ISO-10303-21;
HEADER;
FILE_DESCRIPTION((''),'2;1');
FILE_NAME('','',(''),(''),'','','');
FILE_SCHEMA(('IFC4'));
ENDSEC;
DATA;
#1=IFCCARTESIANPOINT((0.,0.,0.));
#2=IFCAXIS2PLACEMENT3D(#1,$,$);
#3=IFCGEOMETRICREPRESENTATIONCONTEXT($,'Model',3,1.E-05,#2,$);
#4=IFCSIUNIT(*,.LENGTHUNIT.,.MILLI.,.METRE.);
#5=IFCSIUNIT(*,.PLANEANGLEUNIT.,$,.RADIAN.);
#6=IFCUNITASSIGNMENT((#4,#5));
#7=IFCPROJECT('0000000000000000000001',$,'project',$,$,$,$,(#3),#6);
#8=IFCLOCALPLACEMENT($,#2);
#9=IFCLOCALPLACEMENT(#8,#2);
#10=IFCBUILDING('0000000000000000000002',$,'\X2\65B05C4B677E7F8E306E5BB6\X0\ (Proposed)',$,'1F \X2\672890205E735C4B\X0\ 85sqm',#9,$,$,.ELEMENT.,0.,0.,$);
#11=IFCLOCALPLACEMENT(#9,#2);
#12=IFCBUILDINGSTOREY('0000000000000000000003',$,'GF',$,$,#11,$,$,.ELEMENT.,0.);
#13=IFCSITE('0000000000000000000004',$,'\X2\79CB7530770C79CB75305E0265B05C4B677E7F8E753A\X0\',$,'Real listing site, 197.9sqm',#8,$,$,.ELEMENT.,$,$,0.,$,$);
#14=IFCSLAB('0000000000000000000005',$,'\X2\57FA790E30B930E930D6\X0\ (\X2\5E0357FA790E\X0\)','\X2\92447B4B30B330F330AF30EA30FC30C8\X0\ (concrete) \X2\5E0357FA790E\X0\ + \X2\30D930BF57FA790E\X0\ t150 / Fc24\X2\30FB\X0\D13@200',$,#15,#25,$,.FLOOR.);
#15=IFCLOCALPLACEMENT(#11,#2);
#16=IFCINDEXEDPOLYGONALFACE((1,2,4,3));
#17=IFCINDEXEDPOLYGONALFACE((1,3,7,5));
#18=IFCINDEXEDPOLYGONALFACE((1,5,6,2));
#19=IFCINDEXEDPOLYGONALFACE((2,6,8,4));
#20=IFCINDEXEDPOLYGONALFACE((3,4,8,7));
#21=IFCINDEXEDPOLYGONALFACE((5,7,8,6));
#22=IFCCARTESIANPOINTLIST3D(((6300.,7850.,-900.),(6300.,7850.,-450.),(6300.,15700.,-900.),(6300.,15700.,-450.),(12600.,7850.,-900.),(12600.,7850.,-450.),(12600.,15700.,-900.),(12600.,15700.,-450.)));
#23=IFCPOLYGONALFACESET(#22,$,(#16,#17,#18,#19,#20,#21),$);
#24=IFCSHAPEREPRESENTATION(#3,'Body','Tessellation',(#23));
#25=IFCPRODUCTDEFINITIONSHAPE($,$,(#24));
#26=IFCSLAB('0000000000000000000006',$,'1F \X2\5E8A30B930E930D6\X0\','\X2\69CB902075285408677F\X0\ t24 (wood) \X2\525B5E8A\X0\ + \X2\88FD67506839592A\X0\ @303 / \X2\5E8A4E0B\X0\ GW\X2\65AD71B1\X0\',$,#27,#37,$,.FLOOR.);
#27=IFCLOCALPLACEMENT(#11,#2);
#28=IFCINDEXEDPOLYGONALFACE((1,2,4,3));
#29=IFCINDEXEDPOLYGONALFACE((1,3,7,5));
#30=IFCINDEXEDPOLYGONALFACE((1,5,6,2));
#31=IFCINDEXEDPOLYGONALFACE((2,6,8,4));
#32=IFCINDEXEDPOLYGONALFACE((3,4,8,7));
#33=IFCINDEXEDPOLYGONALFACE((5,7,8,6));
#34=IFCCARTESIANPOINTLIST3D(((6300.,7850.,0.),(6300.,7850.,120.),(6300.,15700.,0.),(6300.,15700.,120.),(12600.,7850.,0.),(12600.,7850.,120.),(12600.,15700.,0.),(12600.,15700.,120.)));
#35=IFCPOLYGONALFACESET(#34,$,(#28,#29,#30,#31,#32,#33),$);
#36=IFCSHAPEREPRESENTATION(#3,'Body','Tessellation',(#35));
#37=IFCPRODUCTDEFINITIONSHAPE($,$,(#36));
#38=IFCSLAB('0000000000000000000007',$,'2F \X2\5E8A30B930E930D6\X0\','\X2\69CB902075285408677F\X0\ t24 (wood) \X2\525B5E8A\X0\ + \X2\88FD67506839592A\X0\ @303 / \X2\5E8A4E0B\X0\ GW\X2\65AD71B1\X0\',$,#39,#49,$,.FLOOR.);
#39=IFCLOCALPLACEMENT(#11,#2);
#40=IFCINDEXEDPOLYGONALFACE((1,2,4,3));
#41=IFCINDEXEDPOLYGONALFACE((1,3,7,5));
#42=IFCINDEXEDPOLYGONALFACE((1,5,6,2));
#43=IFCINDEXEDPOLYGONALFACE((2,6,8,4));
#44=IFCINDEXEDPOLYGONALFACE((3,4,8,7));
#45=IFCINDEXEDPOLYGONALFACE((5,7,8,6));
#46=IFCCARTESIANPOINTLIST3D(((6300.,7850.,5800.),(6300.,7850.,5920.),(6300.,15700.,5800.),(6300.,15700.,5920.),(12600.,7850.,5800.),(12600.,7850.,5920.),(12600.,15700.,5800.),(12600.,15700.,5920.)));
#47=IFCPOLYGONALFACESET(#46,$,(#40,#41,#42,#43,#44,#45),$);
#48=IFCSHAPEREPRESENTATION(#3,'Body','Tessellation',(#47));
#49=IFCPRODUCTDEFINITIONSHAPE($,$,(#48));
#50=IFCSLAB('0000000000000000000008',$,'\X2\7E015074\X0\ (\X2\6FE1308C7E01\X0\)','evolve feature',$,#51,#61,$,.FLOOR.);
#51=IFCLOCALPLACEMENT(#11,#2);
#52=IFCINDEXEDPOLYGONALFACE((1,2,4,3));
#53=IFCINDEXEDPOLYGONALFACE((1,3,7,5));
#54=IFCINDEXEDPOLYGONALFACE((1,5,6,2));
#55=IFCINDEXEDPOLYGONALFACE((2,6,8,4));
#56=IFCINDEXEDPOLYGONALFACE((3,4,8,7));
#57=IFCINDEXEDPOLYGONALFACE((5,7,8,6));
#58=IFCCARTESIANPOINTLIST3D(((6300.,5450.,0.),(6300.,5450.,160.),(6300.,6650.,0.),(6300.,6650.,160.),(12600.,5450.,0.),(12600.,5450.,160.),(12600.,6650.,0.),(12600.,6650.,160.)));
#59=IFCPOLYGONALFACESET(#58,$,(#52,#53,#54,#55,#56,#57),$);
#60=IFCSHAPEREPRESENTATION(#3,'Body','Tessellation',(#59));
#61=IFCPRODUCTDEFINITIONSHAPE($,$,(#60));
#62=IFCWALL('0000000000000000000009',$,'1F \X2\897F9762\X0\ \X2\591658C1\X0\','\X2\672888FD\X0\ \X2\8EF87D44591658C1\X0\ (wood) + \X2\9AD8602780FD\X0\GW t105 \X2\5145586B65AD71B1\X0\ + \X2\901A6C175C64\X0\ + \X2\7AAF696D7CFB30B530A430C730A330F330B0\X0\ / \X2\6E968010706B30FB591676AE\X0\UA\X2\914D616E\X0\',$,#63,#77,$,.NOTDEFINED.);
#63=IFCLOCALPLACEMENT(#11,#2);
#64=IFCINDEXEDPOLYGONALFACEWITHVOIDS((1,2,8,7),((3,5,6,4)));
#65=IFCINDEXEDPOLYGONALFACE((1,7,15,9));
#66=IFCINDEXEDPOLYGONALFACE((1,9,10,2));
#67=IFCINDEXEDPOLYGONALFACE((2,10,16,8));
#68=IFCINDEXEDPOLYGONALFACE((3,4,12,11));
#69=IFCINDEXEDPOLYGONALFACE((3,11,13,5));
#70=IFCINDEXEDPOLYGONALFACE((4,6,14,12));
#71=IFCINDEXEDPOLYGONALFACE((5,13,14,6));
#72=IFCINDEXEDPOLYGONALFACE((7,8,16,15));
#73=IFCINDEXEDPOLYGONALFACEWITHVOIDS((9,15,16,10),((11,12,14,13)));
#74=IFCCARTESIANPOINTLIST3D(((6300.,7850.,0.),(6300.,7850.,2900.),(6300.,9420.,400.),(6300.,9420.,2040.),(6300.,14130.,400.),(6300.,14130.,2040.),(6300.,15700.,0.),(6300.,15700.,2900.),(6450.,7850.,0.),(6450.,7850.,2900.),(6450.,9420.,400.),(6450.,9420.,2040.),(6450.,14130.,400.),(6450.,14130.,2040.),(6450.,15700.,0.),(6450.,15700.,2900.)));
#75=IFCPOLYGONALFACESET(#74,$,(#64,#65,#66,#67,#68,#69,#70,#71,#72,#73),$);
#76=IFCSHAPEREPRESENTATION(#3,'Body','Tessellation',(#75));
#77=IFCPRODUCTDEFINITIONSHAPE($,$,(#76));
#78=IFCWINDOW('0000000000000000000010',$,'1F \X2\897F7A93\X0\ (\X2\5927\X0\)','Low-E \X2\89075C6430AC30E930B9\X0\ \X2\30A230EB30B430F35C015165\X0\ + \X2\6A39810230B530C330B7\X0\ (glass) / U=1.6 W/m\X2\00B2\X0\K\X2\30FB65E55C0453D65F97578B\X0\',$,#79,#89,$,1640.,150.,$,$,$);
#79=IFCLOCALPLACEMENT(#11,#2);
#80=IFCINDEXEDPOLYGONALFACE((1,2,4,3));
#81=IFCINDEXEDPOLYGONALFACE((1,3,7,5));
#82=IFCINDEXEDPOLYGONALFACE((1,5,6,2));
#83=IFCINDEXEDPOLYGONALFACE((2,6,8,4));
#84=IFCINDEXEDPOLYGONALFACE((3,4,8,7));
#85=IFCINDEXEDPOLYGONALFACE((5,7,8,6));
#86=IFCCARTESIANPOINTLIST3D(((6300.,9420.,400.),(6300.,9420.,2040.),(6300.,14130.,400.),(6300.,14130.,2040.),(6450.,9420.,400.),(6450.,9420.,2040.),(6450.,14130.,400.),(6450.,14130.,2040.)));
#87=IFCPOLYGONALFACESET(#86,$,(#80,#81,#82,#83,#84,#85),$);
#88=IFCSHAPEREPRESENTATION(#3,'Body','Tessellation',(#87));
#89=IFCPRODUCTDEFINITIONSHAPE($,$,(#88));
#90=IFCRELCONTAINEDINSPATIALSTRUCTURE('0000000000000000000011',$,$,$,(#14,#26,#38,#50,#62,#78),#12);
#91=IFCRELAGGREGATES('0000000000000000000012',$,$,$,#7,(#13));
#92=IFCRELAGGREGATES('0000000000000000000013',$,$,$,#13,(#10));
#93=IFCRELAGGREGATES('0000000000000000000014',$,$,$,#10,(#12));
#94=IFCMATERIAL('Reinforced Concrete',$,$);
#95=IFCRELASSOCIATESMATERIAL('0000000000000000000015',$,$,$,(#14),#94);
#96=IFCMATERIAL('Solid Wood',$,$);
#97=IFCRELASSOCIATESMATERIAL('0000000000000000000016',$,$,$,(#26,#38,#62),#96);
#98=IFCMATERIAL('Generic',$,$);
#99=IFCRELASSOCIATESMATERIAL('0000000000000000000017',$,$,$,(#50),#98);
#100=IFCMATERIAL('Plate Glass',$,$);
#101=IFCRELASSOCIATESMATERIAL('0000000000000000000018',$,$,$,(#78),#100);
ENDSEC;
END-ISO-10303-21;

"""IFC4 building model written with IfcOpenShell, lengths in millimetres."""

from ifc_helpers import new_model, si_unit, frame, frame_2d, origin, place, context, project, spatial, rectangle, extrude, material, element, fill, save


model = new_model("IFC4")

# Units and contexts
model_context = context("Model", 3, precision=1e-05, world=origin())
ifc_project = project(units=[si_unit("LENGTHUNIT", "METRE", prefix="MILLI"), si_unit("PLANEANGLEUNIT", "RADIAN")], contexts=[model_context])

# Site, building, storey
site_placement = place(None, origin())
site = spatial("IfcSite", under=ifc_project, at=site_placement, Name="秋田県秋田市新屋松美町", ObjectType="Real listing site, 197.9sqm", CompositionType="ELEMENT", RefElevation=0.0)
building_placement = place(site_placement, origin())
building = spatial("IfcBuilding", under=site, at=building_placement, Name="新屋松美の家 (Proposed)", ObjectType="1F 木造平屋 85sqm", CompositionType="ELEMENT", ElevationOfRefHeight=0.0, ElevationOfTerrain=0.0)
storey_placement = place(building_placement, origin())
storey = spatial("IfcBuildingStorey", under=building, at=storey_placement, Name="GF", CompositionType="ELEMENT", Elevation=0.0)

# Slabs
ifc_material_1 = material(Name="Reinforced Concrete")
slab_1_placement = place(storey_placement, frame((3150.0, 3925.0, -450.0)))
element("IfcSlab", 1, at=slab_1_placement, inside=storey, material=ifc_material_1, Name="基礎スラブ (布基礎)", Description="鉄筋コンクリート (concrete) 布基礎 + ベタ基礎 t150 / Fc24・D13@200", PredefinedType="FLOOR", context=model_context, shape_type="SweptSolid", body=[
    extrude(rectangle(XDim=6300.0, YDim=7850.0, at=frame_2d((3150.0, 3925.0))), frame((3150.0, 3925.0, -450.0)), (0.0, 0.0, 1.0), 450.0),
])
ifc_material_2 = material(Name="Solid Wood")
slab_2_placement = place(storey_placement, frame((3150.0, 3925.0, 0.0)))
element("IfcSlab", 2, at=slab_2_placement, inside=storey, material=ifc_material_2, Name="1F 床スラブ", Description="構造用合板 t24 (wood) 剛床 + 製材根太 @303 / 床下 GW断熱", PredefinedType="FLOOR", context=model_context, shape_type="SweptSolid", body=[
    extrude(rectangle(XDim=6300.0, YDim=7850.0, at=frame_2d((3150.0, 3925.0))), frame((3150.0, 3925.0, 0.0)), (0.0, 0.0, 1.0), 120.0),
])
slab_3_placement = place(storey_placement, frame((3150.0, 3925.0, 2900.0)))
element("IfcSlab", 3, at=slab_3_placement, inside=storey, material=ifc_material_2, Name="2F 床スラブ", Description="構造用合板 t24 (wood) 剛床 + 製材根太 @303 / 床下 GW断熱", PredefinedType="FLOOR", context=model_context, shape_type="SweptSolid", body=[
    extrude(rectangle(XDim=6300.0, YDim=7850.0, at=frame_2d((3150.0, 3925.0))), frame((3150.0, 3925.0, 2900.0)), (0.0, 0.0, 1.0), 120.0),
])
ifc_material_3 = material(Name="Generic")
slab_4_placement = place(storey_placement, frame((3150.0, 2725.0, 0.0)))
element("IfcSlab", 4, at=slab_4_placement, inside=storey, material=ifc_material_3, Name="縁側 (濡れ縁)", Description="evolve feature", PredefinedType="FLOOR", context=model_context, shape_type="SweptSolid", body=[
    extrude(rectangle(XDim=6300.0, YDim=1200.0, at=frame_2d((3150.0, 600.0))), frame((3150.0, 2725.0, 0.0)), (0.0, 0.0, 1.0), 160.0),
])

# Shared definitions
ifc_material_4 = material(Name="Plate Glass")

# Wall, opening, window
wall_1_placement = place(storey_placement, frame((3150.0, 3925.0, 0.0)))
wall_1 = element("IfcWall", 5, at=wall_1_placement, inside=storey, material=ifc_material_2, Name="1F 西面 外壁", Description="木製 軸組外壁 (wood) + 高性能GW t105 充填断熱 + 通気層 + 窯業系サイディング / 準耐火・外皮UA配慮", PredefinedType="NOTDEFINED", context=model_context, shape_type="SweptSolid", body=[
    extrude(rectangle(XDim=150.0, YDim=7850.0, at=frame_2d((75.0, 3925.0))), frame((3150.0, 3925.0, 0.0)), (0.0, 0.0, 1.0), 2900.0),
])
opening_1_placement = place(storey_placement, frame((3150.0, 4710.0, 200.0)))
opening_1 = element("IfcOpeningElement", 6, at=opening_1_placement, cuts=wall_1, PredefinedType="NOTDEFINED", context=model_context, shape_type="SweptSolid", body=[
    extrude(rectangle(XDim=150.0, YDim=4710.0, at=frame_2d((75.0, 2355.0))), frame((3150.0, 4710.0, 200.0)), (0.0, 0.0, 1.0), 1640.0),
])
window_1_placement = place(storey_placement, frame((3150.0, 4710.0, 200.0)))
window_1 = element("IfcWindow", 7, at=window_1_placement, inside=storey, material=ifc_material_4, Name="1F 西窓 (大)", Description="Low-E 複層ガラス アルゴン封入 + 樹脂サッシ (glass) / U=1.6 W/m²K・日射取得型", OverallHeight=1640.0, OverallWidth=150.0, context=model_context, shape_type="SweptSolid", body=[
    extrude(rectangle(XDim=150.0, YDim=4710.0, at=frame_2d((75.0, 2355.0))), frame((3150.0, 4710.0, 200.0)), (0.0, 0.0, 1.0), 1640.0),
])
fill(opening_1, window_1)

save(model, "model.ifc")
